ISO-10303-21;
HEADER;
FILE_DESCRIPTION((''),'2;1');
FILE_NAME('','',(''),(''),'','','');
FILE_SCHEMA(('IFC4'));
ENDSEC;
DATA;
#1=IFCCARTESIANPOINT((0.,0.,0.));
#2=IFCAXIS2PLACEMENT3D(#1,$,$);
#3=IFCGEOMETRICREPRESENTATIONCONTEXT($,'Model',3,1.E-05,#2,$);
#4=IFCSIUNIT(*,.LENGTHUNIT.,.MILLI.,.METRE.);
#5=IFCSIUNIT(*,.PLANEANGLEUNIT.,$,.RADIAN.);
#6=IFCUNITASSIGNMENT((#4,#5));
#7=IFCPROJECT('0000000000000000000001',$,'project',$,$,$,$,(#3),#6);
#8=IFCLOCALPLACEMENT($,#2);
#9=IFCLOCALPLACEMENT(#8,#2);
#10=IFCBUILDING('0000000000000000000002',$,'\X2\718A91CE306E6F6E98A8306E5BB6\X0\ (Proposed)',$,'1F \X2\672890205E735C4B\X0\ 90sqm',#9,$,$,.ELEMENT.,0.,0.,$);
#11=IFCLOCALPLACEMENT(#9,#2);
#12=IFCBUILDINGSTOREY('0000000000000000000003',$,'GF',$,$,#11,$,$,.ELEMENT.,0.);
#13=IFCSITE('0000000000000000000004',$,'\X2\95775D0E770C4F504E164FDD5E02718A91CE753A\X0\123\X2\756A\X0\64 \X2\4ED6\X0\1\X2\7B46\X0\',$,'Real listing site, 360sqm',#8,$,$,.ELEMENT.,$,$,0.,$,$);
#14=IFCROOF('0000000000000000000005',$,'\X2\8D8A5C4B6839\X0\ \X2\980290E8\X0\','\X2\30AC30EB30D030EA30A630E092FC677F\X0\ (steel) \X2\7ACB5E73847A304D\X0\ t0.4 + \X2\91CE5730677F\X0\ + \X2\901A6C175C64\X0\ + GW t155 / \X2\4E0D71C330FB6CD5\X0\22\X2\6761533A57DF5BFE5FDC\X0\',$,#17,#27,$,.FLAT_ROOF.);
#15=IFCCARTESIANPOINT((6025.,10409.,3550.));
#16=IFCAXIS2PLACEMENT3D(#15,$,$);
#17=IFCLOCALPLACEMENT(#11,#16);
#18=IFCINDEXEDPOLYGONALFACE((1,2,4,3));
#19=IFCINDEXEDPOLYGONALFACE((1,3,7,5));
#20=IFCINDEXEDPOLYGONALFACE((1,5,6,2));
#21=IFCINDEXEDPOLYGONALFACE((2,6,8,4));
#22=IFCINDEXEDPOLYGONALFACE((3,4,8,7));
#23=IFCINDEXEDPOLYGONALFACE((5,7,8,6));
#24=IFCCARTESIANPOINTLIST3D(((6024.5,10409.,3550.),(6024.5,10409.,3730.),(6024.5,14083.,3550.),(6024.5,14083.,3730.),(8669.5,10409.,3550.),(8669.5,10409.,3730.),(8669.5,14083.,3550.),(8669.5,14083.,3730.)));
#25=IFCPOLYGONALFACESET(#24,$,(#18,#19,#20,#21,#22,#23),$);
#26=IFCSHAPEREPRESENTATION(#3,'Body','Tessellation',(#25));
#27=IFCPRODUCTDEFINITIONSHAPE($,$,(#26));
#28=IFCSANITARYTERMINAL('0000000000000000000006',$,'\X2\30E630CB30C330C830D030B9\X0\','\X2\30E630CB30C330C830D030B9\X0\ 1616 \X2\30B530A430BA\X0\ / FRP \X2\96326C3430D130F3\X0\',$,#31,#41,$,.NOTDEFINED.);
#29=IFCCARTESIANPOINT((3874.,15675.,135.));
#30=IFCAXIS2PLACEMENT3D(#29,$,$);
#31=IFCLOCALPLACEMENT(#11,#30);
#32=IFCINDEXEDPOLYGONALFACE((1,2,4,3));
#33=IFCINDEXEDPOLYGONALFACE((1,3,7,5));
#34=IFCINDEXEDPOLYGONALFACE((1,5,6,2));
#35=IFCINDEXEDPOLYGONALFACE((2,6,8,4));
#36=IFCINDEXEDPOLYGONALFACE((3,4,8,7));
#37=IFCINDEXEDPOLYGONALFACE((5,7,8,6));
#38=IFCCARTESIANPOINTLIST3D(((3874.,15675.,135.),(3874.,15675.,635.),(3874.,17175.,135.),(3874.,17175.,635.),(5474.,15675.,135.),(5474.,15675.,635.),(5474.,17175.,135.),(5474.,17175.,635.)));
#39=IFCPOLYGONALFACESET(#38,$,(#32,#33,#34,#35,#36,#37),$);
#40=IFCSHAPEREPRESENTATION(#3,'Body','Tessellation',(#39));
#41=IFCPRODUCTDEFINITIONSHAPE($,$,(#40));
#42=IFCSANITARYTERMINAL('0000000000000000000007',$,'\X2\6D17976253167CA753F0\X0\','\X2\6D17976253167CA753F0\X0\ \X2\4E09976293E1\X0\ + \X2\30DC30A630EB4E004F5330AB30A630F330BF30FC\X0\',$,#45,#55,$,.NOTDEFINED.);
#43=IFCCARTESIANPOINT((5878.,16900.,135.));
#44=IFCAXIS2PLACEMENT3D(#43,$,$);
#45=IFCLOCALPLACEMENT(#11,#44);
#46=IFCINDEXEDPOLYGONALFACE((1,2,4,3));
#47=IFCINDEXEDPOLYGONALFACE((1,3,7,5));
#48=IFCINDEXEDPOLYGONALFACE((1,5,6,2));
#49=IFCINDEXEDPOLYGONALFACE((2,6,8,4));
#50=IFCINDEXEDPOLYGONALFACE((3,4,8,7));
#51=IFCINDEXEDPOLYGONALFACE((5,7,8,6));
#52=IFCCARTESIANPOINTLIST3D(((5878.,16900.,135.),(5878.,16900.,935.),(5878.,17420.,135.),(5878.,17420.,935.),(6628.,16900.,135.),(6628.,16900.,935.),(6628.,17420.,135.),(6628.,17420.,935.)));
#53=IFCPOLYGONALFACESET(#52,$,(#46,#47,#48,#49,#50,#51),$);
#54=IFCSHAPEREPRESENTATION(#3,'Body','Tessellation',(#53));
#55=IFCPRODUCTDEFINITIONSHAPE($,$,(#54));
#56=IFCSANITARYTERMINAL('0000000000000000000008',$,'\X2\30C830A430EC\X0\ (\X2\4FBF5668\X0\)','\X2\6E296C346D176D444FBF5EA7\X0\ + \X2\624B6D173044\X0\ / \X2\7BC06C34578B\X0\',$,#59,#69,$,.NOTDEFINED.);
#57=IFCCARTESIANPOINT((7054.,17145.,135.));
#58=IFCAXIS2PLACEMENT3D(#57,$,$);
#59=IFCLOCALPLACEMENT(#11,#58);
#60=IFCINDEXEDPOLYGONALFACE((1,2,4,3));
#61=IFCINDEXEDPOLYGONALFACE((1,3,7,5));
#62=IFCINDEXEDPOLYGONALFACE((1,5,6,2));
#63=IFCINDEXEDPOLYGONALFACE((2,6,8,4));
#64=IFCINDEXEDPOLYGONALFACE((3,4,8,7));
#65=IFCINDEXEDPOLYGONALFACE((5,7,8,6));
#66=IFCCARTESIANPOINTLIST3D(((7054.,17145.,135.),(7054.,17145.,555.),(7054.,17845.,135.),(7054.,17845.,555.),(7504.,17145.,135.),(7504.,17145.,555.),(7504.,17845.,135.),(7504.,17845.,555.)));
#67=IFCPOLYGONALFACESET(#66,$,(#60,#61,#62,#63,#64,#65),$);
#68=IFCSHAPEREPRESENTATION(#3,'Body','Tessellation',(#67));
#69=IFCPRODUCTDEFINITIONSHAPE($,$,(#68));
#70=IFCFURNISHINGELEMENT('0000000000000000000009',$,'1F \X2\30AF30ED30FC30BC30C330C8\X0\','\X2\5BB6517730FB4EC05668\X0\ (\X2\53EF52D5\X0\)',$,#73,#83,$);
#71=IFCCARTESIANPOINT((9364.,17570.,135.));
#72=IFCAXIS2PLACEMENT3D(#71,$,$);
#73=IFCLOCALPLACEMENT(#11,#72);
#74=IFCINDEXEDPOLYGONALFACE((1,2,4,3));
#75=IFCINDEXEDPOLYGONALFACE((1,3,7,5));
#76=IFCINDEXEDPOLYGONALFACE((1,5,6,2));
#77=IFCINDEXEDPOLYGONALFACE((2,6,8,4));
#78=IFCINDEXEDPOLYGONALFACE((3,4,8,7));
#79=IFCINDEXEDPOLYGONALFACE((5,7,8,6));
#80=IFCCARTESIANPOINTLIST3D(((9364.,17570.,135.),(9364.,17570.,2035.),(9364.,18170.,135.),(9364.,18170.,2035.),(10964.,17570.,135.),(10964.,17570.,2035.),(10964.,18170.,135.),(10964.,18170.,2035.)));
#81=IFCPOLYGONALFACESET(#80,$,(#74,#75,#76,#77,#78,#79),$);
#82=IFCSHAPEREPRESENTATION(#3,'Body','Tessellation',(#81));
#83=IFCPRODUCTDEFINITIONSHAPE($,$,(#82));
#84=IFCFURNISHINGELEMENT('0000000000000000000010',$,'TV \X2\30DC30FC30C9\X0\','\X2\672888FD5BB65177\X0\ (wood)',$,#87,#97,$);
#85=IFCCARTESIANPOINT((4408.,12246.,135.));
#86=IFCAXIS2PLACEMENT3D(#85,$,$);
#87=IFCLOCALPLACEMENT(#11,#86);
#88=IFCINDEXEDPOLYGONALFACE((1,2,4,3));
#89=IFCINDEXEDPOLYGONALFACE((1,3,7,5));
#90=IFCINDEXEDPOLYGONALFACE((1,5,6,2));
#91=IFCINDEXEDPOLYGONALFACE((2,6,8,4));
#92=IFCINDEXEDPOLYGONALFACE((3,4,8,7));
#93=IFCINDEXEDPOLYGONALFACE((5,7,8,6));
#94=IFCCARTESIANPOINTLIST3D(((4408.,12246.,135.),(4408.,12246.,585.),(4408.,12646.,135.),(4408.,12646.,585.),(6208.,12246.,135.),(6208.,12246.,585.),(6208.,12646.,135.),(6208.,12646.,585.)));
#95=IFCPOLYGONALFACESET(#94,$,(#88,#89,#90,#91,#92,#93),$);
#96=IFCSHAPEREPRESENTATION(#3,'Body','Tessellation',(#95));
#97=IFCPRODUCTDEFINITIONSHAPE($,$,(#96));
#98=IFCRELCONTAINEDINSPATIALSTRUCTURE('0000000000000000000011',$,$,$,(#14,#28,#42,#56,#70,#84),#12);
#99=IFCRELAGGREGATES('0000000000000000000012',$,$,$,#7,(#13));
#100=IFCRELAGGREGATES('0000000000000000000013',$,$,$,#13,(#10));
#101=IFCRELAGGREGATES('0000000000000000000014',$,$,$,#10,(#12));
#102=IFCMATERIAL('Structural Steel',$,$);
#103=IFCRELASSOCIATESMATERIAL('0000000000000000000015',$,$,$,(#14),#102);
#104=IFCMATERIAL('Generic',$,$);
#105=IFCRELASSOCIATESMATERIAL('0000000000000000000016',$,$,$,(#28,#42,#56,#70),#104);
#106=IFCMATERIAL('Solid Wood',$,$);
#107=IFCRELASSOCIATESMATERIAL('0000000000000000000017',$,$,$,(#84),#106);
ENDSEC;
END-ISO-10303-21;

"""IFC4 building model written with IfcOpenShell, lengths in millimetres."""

from ifc_helpers import new_model, si_unit, frame, frame_2d, origin, place, context, project, spatial, rectangle, extrude, material, element, save


model = new_model("IFC4")

# Units and contexts
model_context = context("Model", 3, precision=1e-05, world=origin())
ifc_project = project(units=[si_unit("LENGTHUNIT", "METRE", prefix="MILLI"), si_unit("PLANEANGLEUNIT", "RADIAN")], contexts=[model_context])

# Site, building, storey
site_placement = place(None, origin())
site = spatial("IfcSite", under=ifc_project, at=site_placement, Name="長崎県佐世保市熊野町123番64 他1筆", ObjectType="Real listing site, 360sqm", CompositionType="ELEMENT", RefElevation=0.0)
building_placement = place(site_placement, origin())
building = spatial("IfcBuilding", under=site, at=building_placement, Name="熊野の潮風の家 (Proposed)", ObjectType="1F 木造平屋 90sqm", CompositionType="ELEMENT", ElevationOfRefHeight=0.0, ElevationOfTerrain=0.0)
storey_placement = place(building_placement, origin())
storey = spatial("IfcBuildingStorey", under=building, at=storey_placement, Name="GF", CompositionType="ELEMENT", Elevation=0.0)

# Shared definitions
ifc_material_1 = material(Name="Solid Wood")

# Roof
ifc_material_2 = material(Name="Structural Steel")
roof_placement = place(storey_placement, frame((6025.0, 10409.0, 3550.0)))
element("IfcRoof", 1, at=roof_placement, inside=storey, material=ifc_material_2, Name="越屋根 頂部", Description="ガルバリウム鋼板 (steel) 立平葺き t0.4 + 野地板 + 通気層 + GW t155 / 不燃・法22条区域対応", PredefinedType="FLAT_ROOF", context=model_context, shape_type="SweptSolid", body=[
    extrude(rectangle(XDim=2645.0, YDim=3674.0, at=frame_2d((1322.0, 1837.0))), frame((6025.0, 10409.0, 3550.0)), (0.0, 0.0, 1.0), 180.0),
])

# Sanitary terminals
ifc_material_3 = material(Name="Generic")
sanitary_terminal_1_placement = place(storey_placement, frame((3874.0, 15675.0, 135.0)))
element("IfcSanitaryTerminal", 2, at=sanitary_terminal_1_placement, inside=storey, material=ifc_material_3, Name="ユニットバス", Description="ユニットバス 1616 サイズ / FRP 防水パン", PredefinedType="NOTDEFINED", context=model_context, shape_type="SweptSolid", body=[
    extrude(rectangle(XDim=1600.0, YDim=1500.0, at=frame_2d((800.0, 750.0))), frame((3874.0, 15675.0, 135.0)), (0.0, 0.0, 1.0), 500.0),
])
sanitary_terminal_2_placement = place(storey_placement, frame((5878.0, 16900.0, 135.0)))
element("IfcSanitaryTerminal", 3, at=sanitary_terminal_2_placement, inside=storey, material=ifc_material_3, Name="洗面化粧台", Description="洗面化粧台 三面鏡 + ボウル一体カウンター", PredefinedType="NOTDEFINED", context=model_context, shape_type="SweptSolid", body=[
    extrude(rectangle(XDim=750.0, YDim=520.0, at=frame_2d((375.0, 260.0))), frame((5878.0, 16900.0, 135.0)), (0.0, 0.0, 1.0), 800.0),
])
sanitary_terminal_3_placement = place(storey_placement, frame((7054.0, 17145.0, 135.0)))
element("IfcSanitaryTerminal", 4, at=sanitary_terminal_3_placement, inside=storey, material=ifc_material_3, Name="トイレ (便器)", Description="温水洗浄便座 + 手洗い / 節水型", PredefinedType="NOTDEFINED", context=model_context, shape_type="SweptSolid", body=[
    extrude(rectangle(XDim=450.0, YDim=700.0, at=frame_2d((225.0, 350.0))), frame((7054.0, 17145.0, 135.0)), (0.0, 0.0, 1.0), 420.0),
])

# Furnishing elements
furnishing_1_placement = place(storey_placement, frame((9364.0, 17570.0, 135.0)))
element("IfcFurnishingElement", 5, at=furnishing_1_placement, inside=storey, material=ifc_material_3, Name="1F クローゼット", Description="家具・什器 (可動)", context=model_context, shape_type="SweptSolid", body=[
    extrude(rectangle(XDim=1600.0, YDim=600.0, at=frame_2d((800.0, 300.0))), frame((9364.0, 17570.0, 135.0)), (0.0, 0.0, 1.0), 1900.0),
])
furnishing_2_placement = place(storey_placement, frame((4408.0, 12246.0, 135.0)))
element("IfcFurnishingElement", 6, at=furnishing_2_placement, inside=storey, material=ifc_material_1, Name="TV ボード", Description="木製家具 (wood)", context=model_context, shape_type="SweptSolid", body=[
    extrude(rectangle(XDim=1800.0, YDim=400.0, at=frame_2d((900.0, 200.0))), frame((4408.0, 12246.0, 135.0)), (0.0, 0.0, 1.0), 450.0),
])

save(model, "model.ifc")
